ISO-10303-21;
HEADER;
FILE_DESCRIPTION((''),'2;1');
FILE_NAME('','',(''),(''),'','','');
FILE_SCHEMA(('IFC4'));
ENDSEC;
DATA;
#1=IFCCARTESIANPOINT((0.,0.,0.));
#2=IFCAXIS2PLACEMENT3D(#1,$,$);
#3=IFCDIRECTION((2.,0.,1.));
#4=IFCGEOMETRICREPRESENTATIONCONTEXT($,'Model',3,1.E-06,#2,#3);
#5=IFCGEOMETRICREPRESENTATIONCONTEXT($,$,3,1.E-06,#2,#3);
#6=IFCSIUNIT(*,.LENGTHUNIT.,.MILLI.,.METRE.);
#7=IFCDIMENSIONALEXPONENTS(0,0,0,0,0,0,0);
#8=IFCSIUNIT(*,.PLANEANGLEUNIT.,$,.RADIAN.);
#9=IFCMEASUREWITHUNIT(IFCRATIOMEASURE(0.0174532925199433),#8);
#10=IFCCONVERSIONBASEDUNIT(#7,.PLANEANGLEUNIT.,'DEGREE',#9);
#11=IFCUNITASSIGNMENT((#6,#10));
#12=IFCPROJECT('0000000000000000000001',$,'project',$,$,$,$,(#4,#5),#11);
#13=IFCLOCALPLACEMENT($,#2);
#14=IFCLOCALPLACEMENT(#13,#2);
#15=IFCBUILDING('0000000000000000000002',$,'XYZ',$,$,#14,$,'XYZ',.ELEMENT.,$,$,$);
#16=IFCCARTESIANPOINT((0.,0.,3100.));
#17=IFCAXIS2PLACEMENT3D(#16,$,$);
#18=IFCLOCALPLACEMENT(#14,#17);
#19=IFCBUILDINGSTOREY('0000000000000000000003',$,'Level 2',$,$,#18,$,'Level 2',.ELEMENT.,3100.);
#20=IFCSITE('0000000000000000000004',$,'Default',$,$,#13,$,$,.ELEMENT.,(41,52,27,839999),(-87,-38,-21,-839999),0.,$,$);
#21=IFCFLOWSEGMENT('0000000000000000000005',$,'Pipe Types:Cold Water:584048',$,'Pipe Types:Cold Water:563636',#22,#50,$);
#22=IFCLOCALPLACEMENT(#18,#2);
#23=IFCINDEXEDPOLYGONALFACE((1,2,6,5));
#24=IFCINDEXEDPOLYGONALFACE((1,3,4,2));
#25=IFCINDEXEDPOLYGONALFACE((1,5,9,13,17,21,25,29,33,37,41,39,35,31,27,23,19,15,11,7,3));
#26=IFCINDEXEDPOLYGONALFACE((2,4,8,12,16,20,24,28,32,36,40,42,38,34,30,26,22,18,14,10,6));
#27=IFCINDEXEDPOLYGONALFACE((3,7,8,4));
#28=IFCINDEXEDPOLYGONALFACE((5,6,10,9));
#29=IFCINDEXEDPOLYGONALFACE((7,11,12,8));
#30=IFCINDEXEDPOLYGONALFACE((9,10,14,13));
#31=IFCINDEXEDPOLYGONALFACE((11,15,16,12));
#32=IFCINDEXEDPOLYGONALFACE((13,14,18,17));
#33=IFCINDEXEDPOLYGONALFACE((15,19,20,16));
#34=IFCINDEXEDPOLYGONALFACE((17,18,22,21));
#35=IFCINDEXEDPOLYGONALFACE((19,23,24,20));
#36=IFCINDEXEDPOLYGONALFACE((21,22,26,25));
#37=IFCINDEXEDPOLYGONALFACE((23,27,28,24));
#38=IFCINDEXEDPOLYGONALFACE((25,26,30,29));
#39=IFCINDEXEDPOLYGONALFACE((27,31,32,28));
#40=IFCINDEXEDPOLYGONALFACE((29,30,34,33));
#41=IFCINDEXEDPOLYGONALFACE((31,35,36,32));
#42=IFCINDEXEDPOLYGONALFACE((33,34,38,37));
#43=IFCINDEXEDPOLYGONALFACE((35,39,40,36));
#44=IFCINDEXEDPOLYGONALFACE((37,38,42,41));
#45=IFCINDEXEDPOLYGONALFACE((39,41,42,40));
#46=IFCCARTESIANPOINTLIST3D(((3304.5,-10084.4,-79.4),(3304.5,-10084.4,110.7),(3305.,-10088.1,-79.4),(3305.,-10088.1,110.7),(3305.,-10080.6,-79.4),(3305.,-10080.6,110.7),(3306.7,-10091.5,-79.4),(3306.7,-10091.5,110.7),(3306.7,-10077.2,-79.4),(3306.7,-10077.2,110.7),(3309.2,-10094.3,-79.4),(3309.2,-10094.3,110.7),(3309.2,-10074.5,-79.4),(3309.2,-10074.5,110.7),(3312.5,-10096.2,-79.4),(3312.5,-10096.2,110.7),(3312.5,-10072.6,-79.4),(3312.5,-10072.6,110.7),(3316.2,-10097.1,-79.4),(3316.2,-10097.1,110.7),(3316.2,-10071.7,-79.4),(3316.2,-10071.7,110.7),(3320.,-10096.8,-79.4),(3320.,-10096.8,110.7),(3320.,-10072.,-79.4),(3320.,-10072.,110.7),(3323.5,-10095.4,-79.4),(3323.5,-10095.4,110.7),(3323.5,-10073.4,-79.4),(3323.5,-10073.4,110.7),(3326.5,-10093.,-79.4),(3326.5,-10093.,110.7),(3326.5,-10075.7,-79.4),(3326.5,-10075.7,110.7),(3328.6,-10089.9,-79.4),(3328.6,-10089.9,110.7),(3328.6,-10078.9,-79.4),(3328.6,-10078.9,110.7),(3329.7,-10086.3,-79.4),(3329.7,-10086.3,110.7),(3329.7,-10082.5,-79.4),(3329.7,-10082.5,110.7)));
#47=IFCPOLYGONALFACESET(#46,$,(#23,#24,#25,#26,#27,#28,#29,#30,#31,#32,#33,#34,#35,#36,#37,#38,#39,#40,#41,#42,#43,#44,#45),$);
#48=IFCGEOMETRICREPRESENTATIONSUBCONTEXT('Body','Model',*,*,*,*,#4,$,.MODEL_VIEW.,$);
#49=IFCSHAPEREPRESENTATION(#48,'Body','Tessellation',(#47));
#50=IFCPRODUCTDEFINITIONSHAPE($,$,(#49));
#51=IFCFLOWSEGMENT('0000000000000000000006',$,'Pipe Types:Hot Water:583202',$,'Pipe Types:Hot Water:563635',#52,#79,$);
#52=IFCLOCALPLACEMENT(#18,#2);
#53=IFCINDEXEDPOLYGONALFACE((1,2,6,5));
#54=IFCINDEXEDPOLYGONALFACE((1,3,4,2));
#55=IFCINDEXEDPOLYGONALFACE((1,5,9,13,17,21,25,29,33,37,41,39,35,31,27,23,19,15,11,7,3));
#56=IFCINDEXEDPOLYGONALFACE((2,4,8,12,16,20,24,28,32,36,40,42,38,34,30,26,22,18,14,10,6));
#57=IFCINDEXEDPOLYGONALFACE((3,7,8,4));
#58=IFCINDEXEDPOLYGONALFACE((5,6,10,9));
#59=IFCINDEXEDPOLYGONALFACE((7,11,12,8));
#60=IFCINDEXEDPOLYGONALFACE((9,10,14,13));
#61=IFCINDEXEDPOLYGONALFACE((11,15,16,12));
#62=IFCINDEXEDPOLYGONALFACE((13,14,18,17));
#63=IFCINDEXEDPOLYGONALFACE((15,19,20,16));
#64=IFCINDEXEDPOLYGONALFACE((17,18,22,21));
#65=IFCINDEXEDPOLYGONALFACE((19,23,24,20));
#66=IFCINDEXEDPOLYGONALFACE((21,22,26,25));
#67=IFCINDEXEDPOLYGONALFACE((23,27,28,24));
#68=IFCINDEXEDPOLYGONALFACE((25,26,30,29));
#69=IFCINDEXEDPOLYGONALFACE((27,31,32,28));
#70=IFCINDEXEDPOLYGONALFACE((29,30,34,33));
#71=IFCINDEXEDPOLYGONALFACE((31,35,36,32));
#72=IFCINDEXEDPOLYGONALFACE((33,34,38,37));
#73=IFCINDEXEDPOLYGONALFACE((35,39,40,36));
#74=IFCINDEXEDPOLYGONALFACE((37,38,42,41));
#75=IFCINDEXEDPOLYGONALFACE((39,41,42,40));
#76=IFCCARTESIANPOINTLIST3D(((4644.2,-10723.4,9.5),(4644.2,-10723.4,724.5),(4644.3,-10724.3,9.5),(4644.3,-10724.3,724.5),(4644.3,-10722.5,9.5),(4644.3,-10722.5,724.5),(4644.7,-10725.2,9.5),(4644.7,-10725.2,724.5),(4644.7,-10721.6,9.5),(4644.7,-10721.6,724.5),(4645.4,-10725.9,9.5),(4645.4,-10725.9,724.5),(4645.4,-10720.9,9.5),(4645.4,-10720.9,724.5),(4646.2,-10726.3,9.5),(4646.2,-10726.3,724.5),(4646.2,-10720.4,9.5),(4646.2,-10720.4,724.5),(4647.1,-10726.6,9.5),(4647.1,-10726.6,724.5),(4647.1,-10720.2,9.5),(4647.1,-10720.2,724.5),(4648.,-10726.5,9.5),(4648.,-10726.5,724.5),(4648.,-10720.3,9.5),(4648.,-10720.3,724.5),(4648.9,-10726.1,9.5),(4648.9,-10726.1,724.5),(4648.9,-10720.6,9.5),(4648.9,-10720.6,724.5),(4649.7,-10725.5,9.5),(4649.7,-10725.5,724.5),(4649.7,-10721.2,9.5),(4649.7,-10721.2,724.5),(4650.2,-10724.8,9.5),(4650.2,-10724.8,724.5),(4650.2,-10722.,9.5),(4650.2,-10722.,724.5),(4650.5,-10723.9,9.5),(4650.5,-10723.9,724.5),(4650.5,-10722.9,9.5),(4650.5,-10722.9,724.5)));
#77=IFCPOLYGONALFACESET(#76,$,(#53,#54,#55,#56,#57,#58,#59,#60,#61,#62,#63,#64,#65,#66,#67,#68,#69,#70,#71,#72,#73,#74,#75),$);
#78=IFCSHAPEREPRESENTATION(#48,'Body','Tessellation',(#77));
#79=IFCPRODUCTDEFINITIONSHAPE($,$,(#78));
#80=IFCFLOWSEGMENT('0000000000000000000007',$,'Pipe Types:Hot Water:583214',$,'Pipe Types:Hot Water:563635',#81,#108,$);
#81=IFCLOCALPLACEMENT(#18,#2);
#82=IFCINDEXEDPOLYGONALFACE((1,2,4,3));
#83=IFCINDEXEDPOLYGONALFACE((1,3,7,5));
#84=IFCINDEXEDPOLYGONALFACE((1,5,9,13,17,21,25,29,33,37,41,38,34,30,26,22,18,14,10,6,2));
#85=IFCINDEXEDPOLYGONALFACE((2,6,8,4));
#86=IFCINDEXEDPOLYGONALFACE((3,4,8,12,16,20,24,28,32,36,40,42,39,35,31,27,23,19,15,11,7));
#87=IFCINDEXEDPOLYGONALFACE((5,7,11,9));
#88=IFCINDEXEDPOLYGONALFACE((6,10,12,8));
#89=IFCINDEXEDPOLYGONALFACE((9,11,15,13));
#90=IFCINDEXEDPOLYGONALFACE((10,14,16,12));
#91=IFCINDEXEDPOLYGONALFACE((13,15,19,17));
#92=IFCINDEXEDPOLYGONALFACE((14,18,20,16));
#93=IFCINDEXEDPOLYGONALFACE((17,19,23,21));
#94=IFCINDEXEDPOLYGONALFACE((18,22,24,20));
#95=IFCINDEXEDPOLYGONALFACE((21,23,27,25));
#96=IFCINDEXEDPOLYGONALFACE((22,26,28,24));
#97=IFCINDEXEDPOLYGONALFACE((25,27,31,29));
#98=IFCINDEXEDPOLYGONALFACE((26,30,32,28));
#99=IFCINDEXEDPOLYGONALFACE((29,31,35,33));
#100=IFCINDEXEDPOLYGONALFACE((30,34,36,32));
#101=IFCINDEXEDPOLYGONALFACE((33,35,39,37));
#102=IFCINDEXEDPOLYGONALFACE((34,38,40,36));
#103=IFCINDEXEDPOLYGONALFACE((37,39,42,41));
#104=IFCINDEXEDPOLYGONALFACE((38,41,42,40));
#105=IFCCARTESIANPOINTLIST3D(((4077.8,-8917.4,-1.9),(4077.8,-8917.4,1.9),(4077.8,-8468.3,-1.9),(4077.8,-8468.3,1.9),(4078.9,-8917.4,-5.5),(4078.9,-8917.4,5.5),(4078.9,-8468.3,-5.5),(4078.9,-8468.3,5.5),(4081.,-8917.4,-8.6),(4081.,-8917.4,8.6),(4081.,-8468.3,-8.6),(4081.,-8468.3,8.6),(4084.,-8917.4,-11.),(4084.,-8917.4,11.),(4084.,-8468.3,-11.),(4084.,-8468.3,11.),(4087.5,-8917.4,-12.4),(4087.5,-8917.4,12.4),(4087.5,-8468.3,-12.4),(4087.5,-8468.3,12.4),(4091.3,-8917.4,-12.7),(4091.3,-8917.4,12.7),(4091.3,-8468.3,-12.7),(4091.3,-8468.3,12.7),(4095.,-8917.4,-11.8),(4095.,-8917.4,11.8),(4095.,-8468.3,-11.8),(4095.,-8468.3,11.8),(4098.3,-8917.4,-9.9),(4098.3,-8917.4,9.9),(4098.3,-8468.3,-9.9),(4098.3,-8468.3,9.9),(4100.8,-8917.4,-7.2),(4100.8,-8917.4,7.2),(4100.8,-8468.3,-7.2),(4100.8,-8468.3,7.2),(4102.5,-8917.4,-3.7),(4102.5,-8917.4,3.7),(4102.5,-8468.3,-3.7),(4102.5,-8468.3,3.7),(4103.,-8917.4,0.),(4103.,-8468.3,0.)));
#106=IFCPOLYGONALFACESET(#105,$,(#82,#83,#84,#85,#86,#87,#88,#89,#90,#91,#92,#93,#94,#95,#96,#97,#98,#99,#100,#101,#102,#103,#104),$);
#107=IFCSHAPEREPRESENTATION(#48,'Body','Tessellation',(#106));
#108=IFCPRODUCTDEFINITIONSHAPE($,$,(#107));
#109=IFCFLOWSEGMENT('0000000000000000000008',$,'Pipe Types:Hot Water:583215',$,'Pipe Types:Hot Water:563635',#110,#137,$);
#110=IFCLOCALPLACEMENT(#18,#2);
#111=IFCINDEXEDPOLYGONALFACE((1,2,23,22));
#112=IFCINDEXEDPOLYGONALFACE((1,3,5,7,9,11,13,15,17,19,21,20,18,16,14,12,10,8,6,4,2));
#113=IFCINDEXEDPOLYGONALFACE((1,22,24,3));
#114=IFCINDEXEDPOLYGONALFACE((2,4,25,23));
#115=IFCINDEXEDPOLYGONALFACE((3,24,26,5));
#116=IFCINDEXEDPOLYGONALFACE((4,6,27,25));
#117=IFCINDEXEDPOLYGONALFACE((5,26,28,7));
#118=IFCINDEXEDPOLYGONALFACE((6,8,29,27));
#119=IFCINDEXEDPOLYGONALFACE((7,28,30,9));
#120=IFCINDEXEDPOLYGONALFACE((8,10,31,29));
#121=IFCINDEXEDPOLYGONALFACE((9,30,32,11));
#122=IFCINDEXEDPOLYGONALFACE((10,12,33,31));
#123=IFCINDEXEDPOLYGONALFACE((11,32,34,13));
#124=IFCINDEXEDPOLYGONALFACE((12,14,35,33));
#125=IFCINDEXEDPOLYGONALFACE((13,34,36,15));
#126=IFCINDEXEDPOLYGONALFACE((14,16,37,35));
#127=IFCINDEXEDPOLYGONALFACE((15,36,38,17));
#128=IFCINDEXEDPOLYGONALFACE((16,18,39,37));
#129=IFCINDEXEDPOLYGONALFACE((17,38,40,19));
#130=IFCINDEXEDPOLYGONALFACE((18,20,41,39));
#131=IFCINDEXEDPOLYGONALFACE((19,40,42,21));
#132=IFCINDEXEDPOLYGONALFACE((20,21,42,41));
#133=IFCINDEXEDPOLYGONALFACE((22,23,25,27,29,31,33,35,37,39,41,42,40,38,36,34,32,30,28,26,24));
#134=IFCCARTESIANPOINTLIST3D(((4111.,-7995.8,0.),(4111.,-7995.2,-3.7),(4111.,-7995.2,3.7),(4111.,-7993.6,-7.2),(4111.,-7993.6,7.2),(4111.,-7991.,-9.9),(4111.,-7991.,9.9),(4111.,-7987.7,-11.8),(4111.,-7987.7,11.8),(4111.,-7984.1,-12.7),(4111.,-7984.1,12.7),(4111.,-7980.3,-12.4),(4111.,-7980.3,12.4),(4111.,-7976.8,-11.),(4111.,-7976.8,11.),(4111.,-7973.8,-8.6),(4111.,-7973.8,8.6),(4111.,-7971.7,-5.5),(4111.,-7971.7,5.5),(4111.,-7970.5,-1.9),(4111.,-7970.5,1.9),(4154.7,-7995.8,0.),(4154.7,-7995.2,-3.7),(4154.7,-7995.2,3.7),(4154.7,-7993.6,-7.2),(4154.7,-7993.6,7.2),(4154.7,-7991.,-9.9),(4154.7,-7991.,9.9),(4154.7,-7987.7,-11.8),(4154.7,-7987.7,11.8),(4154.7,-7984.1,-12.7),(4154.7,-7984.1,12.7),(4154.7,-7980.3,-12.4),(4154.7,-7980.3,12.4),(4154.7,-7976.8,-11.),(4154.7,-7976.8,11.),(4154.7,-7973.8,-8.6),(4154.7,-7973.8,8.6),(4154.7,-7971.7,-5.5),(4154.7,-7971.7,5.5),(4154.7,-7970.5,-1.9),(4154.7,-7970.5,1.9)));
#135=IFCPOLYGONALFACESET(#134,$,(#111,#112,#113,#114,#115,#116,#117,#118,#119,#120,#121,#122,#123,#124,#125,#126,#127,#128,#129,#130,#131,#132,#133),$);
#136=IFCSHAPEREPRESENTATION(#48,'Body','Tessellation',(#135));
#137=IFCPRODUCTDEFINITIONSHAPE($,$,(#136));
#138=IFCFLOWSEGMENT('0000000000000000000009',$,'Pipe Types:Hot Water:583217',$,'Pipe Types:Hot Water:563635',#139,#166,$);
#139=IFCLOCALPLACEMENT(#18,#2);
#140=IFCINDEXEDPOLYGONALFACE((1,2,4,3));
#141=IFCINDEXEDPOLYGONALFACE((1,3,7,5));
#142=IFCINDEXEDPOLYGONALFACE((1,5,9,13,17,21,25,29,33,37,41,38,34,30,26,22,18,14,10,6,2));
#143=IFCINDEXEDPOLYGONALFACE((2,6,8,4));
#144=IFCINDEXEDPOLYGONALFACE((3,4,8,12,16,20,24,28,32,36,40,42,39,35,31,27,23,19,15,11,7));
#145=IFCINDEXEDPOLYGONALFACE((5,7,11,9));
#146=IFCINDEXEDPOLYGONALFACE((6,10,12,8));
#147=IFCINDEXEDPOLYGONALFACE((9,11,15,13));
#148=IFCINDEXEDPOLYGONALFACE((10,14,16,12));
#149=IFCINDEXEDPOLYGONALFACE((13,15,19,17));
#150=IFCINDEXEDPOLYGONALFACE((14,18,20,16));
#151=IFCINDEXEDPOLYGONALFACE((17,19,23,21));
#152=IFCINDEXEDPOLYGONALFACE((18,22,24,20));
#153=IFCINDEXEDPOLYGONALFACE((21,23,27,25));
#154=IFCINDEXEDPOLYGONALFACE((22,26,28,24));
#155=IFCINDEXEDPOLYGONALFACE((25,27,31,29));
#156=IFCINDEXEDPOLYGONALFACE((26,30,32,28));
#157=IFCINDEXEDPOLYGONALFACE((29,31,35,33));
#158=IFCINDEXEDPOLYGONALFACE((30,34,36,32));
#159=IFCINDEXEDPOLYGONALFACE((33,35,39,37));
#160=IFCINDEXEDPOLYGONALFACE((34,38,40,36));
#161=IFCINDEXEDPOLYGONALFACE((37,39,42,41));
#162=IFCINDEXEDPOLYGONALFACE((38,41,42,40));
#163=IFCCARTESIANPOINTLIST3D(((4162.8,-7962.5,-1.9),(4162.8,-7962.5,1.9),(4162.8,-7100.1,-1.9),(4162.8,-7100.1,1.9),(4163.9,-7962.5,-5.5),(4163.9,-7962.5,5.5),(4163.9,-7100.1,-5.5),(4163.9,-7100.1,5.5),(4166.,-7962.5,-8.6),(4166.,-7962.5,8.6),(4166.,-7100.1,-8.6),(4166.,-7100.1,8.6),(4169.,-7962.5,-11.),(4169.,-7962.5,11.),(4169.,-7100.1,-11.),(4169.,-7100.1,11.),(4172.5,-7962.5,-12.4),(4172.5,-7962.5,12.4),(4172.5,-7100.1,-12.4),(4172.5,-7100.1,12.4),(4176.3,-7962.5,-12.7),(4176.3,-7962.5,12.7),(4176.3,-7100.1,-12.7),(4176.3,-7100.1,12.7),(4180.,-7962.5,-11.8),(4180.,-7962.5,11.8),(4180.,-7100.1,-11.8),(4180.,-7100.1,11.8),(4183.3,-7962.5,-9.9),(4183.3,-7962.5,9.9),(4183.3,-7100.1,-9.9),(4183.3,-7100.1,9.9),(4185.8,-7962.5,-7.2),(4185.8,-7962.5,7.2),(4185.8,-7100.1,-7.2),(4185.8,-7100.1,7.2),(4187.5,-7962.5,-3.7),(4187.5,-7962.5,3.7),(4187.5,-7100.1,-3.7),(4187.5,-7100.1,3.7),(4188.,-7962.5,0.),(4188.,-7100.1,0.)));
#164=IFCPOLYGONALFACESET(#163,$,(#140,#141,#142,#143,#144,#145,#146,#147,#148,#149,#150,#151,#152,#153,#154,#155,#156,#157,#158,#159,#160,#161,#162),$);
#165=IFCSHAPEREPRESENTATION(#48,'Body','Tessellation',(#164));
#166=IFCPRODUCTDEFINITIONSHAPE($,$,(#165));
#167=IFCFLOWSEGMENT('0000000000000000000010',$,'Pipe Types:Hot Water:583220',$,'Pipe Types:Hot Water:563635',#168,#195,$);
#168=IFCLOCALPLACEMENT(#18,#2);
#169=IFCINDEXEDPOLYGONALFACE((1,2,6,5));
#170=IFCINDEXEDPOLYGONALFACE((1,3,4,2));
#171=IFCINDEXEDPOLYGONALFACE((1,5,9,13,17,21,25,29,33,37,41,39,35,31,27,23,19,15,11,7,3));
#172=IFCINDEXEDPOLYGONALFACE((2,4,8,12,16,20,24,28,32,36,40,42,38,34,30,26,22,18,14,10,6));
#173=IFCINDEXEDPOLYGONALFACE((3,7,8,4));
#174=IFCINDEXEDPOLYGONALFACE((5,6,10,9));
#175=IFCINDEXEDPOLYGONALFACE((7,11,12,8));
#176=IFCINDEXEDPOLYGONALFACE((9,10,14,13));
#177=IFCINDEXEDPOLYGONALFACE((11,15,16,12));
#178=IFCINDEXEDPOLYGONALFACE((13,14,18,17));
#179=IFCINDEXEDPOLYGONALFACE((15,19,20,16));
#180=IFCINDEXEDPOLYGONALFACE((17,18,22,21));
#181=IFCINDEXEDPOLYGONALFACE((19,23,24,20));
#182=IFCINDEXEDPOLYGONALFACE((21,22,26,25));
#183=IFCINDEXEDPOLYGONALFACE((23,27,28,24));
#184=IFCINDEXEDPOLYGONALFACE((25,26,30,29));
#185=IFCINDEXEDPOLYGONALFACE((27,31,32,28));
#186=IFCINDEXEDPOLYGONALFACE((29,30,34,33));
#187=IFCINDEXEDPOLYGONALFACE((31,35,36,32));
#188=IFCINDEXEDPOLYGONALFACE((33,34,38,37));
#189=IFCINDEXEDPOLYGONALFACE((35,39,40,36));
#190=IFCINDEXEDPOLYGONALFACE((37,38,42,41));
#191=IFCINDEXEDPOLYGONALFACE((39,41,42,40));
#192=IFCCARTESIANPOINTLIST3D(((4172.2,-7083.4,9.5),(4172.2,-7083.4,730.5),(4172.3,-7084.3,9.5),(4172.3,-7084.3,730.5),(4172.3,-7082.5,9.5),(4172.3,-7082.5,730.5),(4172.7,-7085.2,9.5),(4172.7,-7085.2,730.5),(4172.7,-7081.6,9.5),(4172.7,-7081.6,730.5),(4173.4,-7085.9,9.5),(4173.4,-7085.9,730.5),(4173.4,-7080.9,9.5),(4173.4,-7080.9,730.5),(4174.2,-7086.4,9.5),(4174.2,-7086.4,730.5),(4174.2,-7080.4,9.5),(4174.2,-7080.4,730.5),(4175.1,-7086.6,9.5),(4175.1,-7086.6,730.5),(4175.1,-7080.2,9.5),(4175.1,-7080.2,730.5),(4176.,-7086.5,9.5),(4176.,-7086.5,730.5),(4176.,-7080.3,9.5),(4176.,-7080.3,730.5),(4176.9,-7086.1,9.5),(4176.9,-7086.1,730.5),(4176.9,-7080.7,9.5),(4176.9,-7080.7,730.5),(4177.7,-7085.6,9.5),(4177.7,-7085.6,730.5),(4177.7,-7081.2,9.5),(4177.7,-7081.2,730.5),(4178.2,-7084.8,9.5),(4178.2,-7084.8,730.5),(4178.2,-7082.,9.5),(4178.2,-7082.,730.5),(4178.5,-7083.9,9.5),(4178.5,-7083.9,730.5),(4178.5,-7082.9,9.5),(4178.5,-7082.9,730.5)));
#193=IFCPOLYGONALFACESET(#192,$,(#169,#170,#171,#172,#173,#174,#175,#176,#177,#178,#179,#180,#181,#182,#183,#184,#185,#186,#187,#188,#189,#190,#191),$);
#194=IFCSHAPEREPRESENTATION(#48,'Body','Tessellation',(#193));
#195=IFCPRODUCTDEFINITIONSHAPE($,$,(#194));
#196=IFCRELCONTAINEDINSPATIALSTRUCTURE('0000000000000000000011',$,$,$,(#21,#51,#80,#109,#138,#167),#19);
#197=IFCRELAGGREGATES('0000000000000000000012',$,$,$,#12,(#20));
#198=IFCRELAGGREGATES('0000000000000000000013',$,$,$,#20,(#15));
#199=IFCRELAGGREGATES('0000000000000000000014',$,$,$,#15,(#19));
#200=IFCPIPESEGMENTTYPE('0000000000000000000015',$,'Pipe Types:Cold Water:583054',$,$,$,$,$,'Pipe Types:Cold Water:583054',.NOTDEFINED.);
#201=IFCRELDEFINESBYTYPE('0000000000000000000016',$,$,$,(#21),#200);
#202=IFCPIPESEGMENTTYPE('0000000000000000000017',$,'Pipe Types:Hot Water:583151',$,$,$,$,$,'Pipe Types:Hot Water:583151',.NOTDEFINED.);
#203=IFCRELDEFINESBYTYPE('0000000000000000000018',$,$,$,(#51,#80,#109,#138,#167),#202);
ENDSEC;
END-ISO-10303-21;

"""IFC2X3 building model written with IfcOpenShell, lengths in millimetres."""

from ifc_helpers import new_model, entity, si_unit, converted_unit, direction, frame, origin, origin_2d_with_axis, place, context, subcontext, project, spatial, circle, extrude, type_object, element, save


model = new_model("IFC2X3")

# Units and contexts
model_context = context("Model", 3, precision=1e-06, world=origin(), true_north=direction((2.0, 0.0, 1.0)))
context_of_model = context(None, 3, precision=1e-06, world=origin(), true_north=direction((2.0, 0.0, 1.0)))
body_context = subcontext(model_context, "Body", "Model", "MODEL_VIEW")
ifc_project = project(units=[si_unit("LENGTHUNIT", "METRE", prefix="MILLI"), converted_unit("PLANEANGLEUNIT", "DEGREE", entity("IfcRatioMeasure", 0.0174532925199433), si_unit("PLANEANGLEUNIT", "RADIAN"), dimensions=[0, 0, 0, 0, 0, 0, 0])], contexts=[model_context, context_of_model])

# Site, building, storey
site_placement = place(None, origin())
site = spatial("IfcSite", under=ifc_project, at=site_placement, Name="Default", CompositionType="ELEMENT", RefLatitude=(41, 52, 27, 839999), RefLongitude=(-87, -38, -21, -839999), RefElevation=0.0)
building_placement = place(site_placement, origin())
building = spatial("IfcBuilding", under=site, at=building_placement, Name="XYZ", LongName="XYZ", CompositionType="ELEMENT")
storey_placement = place(building_placement, frame((0.0, 0.0, 3100.0)))
storey = spatial("IfcBuildingStorey", under=building, at=storey_placement, Name="Level 2", LongName="Level 2", CompositionType="ELEMENT", Elevation=3100.0)

# Flow segments
pipe_segment_type_1 = type_object("IfcPipeSegmentType", Name="Pipe Types:Cold Water:583054", ElementType="Pipe Types:Cold Water:583054", PredefinedType="NOTDEFINED")
flow_segment_1_placement = place(storey_placement, origin())
element("IfcFlowSegment", 1, at=flow_segment_1_placement, inside=storey, type_object=pipe_segment_type_1, Name="Pipe Types:Cold Water:584048", ObjectType="Pipe Types:Cold Water:563636", context=body_context, shape_type="SweptSolid", body=[
    extrude(circle(Radius=12.7, at=origin_2d_with_axis()), frame((3317.2, -10084.4, -79.4), z_axis=(0.0, 0.0, 1.0), x_axis=(-1.0, 0.0, 0.0)), (0.0, 0.0, 1.0), 190.0),
])
pipe_segment_type_2 = type_object("IfcPipeSegmentType", Name="Pipe Types:Hot Water:583151", ElementType="Pipe Types:Hot Water:583151", PredefinedType="NOTDEFINED")
flow_segment_2_placement = place(storey_placement, origin())
element("IfcFlowSegment", 2, at=flow_segment_2_placement, inside=storey, type_object=pipe_segment_type_2, Name="Pipe Types:Hot Water:583202", ObjectType="Pipe Types:Hot Water:563635", context=body_context, shape_type="SweptSolid", body=[
    extrude(circle(Radius=3.2, at=origin_2d_with_axis()), frame((4647.3, -10723.4, 9.5), z_axis=(0.0, 0.0, 1.0), x_axis=(-1.0, 0.0, 0.0)), (0.0, 0.0, 1.0), 714.9),
])
flow_segment_3_placement = place(storey_placement, origin())
element("IfcFlowSegment", 3, at=flow_segment_3_placement, inside=storey, type_object=pipe_segment_type_2, Name="Pipe Types:Hot Water:583214", ObjectType="Pipe Types:Hot Water:563635", context=body_context, shape_type="SweptSolid", body=[
    extrude(circle(Radius=12.7, at=origin_2d_with_axis()), frame((4090.3, -8917.4, 0.0), z_axis=(0.0, 1.0, 0.0), x_axis=(1.0, 0.0, 0.0)), (0.0, 0.0, 1.0), 449.1),
])
flow_segment_4_placement = place(storey_placement, origin())
element("IfcFlowSegment", 4, at=flow_segment_4_placement, inside=storey, type_object=pipe_segment_type_2, Name="Pipe Types:Hot Water:583215", ObjectType="Pipe Types:Hot Water:563635", context=body_context, shape_type="SweptSolid", body=[
    extrude(circle(Radius=12.7, at=origin_2d_with_axis()), frame((4111.0, -7983.1, 0.0), z_axis=(1.0, 0.0, 0.0), x_axis=(0.0, -1.0, 0.0)), (0.0, 0.0, 1.0), 43.7),
])
flow_segment_5_placement = place(storey_placement, origin())
element("IfcFlowSegment", 5, at=flow_segment_5_placement, inside=storey, type_object=pipe_segment_type_2, Name="Pipe Types:Hot Water:583217", ObjectType="Pipe Types:Hot Water:563635", context=body_context, shape_type="SweptSolid", body=[
    extrude(circle(Radius=12.7, at=origin_2d_with_axis()), frame((4175.3, -7962.5, 0.0), z_axis=(0.0, 1.0, 0.0), x_axis=(1.0, 0.0, 0.0)), (0.0, 0.0, 1.0), 862.4),
])
flow_segment_6_placement = place(storey_placement, origin())
element("IfcFlowSegment", 6, at=flow_segment_6_placement, inside=storey, type_object=pipe_segment_type_2, Name="Pipe Types:Hot Water:583220", ObjectType="Pipe Types:Hot Water:563635", context=body_context, shape_type="SweptSolid", body=[
    extrude(circle(Radius=3.2, at=origin_2d_with_axis()), frame((4175.3, -7083.4, 9.5), z_axis=(0.0, 0.0, 1.0), x_axis=(-1.0, 0.0, 0.0)), (0.0, 0.0, 1.0), 720.9),
])

save(model, "model.ifc")
